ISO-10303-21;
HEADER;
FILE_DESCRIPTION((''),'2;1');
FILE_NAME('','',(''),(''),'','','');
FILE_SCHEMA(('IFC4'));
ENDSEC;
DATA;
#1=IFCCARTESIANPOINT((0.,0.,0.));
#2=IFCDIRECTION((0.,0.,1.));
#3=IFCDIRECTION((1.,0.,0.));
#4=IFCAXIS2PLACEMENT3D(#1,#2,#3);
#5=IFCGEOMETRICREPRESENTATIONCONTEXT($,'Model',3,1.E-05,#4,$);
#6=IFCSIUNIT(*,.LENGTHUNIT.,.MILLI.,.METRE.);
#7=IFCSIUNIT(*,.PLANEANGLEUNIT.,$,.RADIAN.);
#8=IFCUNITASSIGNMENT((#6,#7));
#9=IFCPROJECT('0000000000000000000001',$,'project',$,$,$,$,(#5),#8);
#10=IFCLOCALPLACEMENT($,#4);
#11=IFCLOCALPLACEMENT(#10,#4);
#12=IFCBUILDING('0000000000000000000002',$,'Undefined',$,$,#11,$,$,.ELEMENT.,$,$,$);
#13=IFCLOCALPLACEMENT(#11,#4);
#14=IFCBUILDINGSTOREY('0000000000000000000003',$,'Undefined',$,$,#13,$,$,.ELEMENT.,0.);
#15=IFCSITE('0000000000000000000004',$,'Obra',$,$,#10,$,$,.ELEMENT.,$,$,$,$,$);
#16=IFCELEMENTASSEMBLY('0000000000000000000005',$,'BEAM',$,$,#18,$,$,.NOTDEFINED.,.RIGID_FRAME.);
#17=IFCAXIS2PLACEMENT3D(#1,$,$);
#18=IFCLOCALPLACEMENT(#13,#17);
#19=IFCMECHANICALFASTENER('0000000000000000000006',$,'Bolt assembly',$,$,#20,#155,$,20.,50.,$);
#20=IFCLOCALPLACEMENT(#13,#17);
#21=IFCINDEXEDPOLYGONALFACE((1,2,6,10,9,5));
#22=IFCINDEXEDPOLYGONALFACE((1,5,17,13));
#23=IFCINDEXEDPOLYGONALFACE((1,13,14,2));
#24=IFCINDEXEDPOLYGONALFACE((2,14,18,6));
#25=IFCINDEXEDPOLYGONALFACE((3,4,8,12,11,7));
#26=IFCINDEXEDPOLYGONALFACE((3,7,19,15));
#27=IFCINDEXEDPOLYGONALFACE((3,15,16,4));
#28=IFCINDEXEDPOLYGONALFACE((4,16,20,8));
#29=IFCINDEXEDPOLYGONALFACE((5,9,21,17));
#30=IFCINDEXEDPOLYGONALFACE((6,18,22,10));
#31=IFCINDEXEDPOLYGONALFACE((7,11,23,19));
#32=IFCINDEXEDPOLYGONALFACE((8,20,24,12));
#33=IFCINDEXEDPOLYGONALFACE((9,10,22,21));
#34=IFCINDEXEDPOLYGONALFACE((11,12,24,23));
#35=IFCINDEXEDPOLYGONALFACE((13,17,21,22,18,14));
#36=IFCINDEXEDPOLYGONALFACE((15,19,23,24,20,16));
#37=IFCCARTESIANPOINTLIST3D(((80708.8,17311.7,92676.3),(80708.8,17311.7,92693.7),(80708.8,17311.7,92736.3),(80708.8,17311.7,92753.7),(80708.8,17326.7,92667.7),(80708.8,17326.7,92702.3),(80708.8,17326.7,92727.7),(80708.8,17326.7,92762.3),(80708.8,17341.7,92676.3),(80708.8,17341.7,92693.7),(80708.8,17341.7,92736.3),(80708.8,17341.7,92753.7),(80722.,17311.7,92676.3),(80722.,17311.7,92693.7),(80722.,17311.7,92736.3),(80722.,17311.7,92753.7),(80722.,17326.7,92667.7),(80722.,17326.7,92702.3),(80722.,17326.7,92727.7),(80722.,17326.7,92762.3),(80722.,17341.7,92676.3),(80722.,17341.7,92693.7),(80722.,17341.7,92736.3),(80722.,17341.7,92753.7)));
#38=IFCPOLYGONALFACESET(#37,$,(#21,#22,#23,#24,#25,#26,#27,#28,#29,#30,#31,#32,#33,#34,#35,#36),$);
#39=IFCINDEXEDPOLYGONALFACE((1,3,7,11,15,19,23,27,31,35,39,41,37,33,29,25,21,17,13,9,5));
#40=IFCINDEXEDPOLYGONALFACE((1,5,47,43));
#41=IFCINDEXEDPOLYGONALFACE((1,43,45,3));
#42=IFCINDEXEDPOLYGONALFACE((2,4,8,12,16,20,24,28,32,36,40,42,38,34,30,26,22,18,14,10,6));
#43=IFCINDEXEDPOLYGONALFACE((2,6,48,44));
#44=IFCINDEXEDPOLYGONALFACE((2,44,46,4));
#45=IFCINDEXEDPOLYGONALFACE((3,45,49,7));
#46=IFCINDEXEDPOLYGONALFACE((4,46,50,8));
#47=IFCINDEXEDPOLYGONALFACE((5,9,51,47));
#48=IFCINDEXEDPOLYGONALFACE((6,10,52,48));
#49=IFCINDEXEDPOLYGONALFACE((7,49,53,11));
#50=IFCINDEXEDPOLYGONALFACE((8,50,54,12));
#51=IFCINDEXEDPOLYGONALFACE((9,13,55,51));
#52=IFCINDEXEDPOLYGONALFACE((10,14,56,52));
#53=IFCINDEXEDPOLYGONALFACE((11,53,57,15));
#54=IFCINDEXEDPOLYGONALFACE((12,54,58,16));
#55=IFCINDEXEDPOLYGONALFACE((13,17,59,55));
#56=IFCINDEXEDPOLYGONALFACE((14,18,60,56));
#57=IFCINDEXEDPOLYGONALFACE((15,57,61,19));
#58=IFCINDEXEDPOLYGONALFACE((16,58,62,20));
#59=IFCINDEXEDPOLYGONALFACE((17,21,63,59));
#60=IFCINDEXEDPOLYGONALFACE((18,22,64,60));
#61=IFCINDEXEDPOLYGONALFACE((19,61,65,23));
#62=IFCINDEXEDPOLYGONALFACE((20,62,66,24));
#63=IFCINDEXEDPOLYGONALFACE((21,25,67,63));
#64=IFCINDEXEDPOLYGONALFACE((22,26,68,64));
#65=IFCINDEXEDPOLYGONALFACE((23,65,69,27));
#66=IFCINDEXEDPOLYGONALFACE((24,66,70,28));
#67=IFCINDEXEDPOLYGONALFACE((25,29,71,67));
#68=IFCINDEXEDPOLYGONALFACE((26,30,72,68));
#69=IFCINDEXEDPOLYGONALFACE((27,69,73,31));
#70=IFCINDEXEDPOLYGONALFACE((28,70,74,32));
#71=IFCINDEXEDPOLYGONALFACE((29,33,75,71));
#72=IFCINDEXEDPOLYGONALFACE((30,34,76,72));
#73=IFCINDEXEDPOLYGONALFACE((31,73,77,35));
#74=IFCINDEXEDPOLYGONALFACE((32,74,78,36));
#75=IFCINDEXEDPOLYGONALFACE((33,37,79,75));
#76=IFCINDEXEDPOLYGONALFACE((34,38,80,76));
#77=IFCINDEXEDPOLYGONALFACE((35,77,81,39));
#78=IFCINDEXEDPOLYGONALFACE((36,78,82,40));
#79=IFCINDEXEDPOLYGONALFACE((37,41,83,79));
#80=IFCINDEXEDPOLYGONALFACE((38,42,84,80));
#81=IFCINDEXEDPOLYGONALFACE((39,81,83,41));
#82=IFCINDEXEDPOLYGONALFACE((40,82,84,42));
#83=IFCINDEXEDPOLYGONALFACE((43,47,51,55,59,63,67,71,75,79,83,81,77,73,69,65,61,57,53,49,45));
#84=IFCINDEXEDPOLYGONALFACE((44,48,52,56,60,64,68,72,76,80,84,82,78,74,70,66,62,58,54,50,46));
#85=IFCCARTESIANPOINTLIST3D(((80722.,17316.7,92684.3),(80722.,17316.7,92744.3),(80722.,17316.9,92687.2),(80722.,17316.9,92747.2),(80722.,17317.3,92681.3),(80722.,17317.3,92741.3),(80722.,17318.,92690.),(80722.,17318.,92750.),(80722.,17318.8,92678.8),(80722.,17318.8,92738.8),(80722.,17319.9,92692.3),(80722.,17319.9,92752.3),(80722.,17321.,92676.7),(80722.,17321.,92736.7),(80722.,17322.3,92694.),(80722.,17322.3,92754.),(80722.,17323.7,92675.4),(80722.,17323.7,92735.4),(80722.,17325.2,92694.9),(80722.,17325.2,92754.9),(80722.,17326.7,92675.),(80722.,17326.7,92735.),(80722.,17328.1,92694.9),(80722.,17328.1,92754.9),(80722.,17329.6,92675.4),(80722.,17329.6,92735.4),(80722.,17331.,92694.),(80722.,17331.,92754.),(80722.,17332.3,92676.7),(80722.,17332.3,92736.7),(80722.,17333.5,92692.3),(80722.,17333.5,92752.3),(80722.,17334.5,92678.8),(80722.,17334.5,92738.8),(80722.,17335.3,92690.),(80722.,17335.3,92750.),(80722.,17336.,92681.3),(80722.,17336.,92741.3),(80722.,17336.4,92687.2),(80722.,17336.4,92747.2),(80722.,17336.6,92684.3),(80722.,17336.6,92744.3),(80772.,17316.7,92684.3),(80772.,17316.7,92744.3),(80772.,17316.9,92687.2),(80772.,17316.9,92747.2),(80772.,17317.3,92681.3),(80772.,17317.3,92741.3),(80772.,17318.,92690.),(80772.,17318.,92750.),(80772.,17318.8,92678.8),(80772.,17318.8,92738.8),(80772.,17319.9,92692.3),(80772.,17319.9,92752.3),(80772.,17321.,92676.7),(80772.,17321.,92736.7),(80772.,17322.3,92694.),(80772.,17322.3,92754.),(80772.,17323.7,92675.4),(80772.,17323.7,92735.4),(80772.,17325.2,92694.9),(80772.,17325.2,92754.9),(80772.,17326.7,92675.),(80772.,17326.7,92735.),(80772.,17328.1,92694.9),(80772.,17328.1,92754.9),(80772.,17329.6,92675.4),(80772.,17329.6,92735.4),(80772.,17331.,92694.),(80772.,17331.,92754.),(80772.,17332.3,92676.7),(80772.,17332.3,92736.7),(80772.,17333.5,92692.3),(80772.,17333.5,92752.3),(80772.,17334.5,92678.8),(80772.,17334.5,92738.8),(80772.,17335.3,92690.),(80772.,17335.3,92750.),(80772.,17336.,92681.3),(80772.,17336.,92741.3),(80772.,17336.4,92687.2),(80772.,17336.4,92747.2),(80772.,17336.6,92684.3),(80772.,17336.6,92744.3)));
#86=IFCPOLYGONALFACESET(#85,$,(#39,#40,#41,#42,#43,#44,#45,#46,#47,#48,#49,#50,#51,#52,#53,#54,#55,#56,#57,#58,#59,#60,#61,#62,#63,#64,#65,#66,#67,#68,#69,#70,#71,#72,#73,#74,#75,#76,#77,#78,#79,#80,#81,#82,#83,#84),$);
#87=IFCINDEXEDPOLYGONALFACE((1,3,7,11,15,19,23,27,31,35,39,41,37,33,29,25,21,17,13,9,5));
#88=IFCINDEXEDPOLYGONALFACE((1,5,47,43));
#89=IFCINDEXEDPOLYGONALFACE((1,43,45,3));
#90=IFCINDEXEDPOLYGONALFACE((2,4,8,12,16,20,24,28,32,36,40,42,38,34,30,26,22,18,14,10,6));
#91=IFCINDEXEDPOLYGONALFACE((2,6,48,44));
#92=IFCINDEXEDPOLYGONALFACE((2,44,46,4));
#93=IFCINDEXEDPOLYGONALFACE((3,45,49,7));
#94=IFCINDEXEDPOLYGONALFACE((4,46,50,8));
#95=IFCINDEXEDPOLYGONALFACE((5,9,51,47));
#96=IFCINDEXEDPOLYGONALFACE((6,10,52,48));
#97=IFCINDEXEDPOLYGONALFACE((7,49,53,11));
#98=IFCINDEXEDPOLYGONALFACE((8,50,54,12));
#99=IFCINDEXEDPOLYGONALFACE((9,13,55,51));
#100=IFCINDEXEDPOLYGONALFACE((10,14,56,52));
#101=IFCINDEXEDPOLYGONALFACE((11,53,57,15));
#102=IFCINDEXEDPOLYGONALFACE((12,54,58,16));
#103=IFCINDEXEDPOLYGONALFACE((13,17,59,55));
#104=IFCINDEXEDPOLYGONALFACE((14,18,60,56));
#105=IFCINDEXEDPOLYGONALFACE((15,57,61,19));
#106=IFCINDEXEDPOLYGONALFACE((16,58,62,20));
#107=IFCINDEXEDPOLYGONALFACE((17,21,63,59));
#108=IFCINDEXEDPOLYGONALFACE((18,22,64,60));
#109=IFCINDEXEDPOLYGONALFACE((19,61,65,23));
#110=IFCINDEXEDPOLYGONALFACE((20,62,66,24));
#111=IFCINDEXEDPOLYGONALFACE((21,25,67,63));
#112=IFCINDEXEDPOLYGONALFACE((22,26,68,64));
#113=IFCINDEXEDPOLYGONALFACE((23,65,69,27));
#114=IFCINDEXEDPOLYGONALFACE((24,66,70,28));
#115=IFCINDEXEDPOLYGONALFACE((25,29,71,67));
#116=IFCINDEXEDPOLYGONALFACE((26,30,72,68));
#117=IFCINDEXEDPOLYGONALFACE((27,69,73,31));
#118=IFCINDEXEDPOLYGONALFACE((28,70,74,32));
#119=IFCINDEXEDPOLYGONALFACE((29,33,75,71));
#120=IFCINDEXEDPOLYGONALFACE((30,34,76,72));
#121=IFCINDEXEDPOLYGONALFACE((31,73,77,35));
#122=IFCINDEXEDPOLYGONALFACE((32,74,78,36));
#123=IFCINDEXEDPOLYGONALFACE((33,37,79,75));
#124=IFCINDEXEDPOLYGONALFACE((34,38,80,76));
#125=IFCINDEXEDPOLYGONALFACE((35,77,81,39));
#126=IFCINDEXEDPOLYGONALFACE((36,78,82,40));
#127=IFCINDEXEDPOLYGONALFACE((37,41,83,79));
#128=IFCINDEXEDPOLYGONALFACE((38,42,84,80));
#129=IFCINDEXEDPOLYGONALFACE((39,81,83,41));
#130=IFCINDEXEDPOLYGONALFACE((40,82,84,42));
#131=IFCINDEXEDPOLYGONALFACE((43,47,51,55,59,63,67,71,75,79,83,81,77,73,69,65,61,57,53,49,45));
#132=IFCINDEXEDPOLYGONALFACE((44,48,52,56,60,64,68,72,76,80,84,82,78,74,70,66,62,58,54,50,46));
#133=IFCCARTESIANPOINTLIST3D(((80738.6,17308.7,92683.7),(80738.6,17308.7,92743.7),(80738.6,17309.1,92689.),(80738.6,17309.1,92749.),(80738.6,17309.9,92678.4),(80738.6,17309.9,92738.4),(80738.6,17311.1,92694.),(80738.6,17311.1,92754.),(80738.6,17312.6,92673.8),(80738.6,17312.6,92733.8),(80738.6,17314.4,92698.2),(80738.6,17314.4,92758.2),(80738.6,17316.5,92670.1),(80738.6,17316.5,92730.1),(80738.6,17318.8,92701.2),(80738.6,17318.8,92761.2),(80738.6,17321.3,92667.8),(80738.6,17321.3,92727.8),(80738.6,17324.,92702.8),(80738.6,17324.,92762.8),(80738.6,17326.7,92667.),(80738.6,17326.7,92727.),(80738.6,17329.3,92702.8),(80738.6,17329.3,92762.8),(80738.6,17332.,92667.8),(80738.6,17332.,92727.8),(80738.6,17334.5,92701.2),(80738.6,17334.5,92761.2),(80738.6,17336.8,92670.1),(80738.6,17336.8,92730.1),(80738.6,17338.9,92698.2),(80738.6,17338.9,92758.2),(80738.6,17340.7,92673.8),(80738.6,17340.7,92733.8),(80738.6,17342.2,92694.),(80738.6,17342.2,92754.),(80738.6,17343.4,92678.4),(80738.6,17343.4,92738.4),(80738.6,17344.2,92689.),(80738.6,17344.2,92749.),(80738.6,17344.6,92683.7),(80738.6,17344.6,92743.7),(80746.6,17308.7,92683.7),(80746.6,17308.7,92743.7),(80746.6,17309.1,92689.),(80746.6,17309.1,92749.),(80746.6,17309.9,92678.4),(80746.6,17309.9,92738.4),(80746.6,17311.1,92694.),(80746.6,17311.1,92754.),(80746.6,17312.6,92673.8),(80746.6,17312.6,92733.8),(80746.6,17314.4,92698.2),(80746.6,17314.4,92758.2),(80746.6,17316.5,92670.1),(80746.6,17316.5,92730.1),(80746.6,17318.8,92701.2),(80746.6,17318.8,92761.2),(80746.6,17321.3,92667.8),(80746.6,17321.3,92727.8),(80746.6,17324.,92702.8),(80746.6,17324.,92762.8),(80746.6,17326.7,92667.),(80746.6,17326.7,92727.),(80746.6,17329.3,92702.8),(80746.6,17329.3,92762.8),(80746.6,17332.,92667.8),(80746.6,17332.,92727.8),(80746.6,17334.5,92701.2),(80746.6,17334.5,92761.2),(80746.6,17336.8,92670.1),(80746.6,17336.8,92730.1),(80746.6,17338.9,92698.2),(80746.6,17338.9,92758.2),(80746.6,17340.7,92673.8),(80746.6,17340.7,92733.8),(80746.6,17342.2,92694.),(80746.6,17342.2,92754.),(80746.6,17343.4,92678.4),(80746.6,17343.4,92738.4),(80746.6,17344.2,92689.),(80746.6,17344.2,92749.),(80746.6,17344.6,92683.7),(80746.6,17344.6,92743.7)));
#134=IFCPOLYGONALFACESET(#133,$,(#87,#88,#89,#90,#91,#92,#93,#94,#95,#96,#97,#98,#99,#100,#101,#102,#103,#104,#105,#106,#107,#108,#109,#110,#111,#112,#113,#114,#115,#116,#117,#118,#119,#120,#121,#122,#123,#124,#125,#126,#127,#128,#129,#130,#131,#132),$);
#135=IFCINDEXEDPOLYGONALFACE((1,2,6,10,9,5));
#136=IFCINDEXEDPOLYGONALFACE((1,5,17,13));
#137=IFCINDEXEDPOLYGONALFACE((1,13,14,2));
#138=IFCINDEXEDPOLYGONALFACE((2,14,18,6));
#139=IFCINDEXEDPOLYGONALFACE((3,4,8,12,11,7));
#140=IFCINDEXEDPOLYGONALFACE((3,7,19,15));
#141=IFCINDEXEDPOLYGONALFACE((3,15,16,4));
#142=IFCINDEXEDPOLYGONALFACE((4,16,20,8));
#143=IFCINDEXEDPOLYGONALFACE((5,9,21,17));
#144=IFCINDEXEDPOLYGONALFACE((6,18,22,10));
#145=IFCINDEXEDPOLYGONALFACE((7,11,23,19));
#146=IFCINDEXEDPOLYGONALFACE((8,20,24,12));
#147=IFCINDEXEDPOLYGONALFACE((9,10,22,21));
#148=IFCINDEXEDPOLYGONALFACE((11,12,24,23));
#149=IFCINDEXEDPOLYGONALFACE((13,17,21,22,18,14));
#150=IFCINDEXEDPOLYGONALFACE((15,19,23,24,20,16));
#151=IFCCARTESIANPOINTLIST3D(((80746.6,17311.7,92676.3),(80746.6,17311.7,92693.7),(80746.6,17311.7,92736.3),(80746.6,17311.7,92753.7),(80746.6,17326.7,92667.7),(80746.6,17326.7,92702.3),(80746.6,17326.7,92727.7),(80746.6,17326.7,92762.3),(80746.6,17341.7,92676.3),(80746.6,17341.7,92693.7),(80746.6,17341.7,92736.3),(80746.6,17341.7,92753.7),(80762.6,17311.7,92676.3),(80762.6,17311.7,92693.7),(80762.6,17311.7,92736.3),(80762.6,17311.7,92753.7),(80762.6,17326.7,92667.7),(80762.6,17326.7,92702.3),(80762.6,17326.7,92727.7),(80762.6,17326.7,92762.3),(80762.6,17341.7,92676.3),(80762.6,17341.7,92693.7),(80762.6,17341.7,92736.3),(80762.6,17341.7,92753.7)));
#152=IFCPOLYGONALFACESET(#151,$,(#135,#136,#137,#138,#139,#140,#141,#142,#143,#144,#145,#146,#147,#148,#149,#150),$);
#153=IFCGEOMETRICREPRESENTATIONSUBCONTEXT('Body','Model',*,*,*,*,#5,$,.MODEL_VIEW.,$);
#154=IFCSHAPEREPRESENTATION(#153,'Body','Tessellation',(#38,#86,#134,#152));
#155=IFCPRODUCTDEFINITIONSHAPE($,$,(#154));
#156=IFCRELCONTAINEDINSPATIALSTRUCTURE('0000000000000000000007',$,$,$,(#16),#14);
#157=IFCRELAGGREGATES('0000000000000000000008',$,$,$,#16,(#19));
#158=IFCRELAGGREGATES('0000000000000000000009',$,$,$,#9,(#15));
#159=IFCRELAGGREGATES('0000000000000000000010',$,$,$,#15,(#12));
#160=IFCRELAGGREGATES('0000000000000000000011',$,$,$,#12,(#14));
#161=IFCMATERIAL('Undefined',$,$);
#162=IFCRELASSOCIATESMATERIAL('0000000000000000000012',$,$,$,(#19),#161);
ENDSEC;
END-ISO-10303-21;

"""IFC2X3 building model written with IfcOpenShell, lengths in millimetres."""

from ifc_helpers import new_model, si_unit, frame, origin_with_axes, origin_2d_with_axis, place, context, subcontext, project, spatial, polyline, circle, outline, extrude, source, transform, mapped, material, element, aggregate, save


model = new_model("IFC2X3")

# Units and contexts
model_context = context("Model", 3, precision=1e-05, world=origin_with_axes())
body_context = subcontext(model_context, "Body", "Model", "MODEL_VIEW")
ifc_project = project(units=[si_unit("LENGTHUNIT", "METRE", prefix="MILLI"), si_unit("PLANEANGLEUNIT", "RADIAN")], contexts=[model_context])

# Site, building, storey
site_placement = place(None, origin_with_axes())
site = spatial("IfcSite", under=ifc_project, at=site_placement, Name="Obra", CompositionType="ELEMENT")
building_placement = place(site_placement, origin_with_axes())
building = spatial("IfcBuilding", under=site, at=building_placement, Name="Undefined", CompositionType="ELEMENT")
storey_placement = place(building_placement, origin_with_axes())
storey = spatial("IfcBuildingStorey", under=building, at=storey_placement, Name="Undefined", CompositionType="ELEMENT", Elevation=0.0)

# Shared definitions
ifc_material_1 = material(Name="Undefined")
shared_shape_1 = source(origin_with_axes(), body_context, "Body", "SweptSolid", [
    extrude(outline(polyline([(17.3, 0.0), (8.7, 15.0), (-8.7, 15.0), (-17.3, 0.0), (-8.7, -15.0), (8.7, -15.0), (17.3, 0.0)])), frame((0.0, -26.5, 0.0), z_axis=(0.0, 1.0, 0.0), x_axis=(1.0, 0.0, 0.0)), (0.0, 0.0, 1.0), 13.2),
    extrude(circle(Radius=10.0, at=origin_2d_with_axis()), frame((0.0, -13.3, 0.0), z_axis=(0.0, 1.0, 0.0), x_axis=(1.0, 0.0, 0.0)), (0.0, 0.0, 1.0), 50.0),
    extrude(circle(Radius=18.0, at=origin_2d_with_axis()), frame((0.0, 3.3, 0.0), z_axis=(0.0, 1.0, 0.0), x_axis=(1.0, 0.0, 0.0)), (0.0, 0.0, 1.0), 8.0),
    extrude(outline(polyline([(17.3, 0.0), (8.7, 15.0), (-8.7, 15.0), (-17.3, 0.0), (-8.7, -15.0), (8.7, -15.0), (17.3, 0.0)])), frame((0.0, 11.3, 0.0), z_axis=(0.0, 1.0, 0.0), x_axis=(1.0, 0.0, 0.0)), (0.0, 0.0, 1.0), 16.0),
])

# Element assembly, mechanical fastener
assembly_1_placement = place(storey_placement, origin_with_axes())
assembly_1 = element("IfcElementAssembly", 1, at=assembly_1_placement, inside=storey, Name="BEAM", AssemblyPlace="NOTDEFINED", PredefinedType="RIGID_FRAME")
mechanical_fastener_1_placement = place(assembly_1_placement, frame((80735.3, 17366.7, 92850.0), z_axis=(0.0, -1.0, 0.0), x_axis=(0.0, 0.0, -1.0)))
mechanical_fastener_1 = element("IfcMechanicalFastener", 2, at=mechanical_fastener_1_placement, material=ifc_material_1, Name="Bolt assembly", NominalDiameter=20.0, NominalLength=50.0, context=body_context, shape_type="MappedRepresentation", body=[
    mapped(shared_shape_1, transform((105.0, 0.0, 40.0))),
    mapped(shared_shape_1, transform((165.0, 0.0, 40.0))),
])
aggregate(assembly_1, [mechanical_fastener_1])

save(model, "model.ifc")
